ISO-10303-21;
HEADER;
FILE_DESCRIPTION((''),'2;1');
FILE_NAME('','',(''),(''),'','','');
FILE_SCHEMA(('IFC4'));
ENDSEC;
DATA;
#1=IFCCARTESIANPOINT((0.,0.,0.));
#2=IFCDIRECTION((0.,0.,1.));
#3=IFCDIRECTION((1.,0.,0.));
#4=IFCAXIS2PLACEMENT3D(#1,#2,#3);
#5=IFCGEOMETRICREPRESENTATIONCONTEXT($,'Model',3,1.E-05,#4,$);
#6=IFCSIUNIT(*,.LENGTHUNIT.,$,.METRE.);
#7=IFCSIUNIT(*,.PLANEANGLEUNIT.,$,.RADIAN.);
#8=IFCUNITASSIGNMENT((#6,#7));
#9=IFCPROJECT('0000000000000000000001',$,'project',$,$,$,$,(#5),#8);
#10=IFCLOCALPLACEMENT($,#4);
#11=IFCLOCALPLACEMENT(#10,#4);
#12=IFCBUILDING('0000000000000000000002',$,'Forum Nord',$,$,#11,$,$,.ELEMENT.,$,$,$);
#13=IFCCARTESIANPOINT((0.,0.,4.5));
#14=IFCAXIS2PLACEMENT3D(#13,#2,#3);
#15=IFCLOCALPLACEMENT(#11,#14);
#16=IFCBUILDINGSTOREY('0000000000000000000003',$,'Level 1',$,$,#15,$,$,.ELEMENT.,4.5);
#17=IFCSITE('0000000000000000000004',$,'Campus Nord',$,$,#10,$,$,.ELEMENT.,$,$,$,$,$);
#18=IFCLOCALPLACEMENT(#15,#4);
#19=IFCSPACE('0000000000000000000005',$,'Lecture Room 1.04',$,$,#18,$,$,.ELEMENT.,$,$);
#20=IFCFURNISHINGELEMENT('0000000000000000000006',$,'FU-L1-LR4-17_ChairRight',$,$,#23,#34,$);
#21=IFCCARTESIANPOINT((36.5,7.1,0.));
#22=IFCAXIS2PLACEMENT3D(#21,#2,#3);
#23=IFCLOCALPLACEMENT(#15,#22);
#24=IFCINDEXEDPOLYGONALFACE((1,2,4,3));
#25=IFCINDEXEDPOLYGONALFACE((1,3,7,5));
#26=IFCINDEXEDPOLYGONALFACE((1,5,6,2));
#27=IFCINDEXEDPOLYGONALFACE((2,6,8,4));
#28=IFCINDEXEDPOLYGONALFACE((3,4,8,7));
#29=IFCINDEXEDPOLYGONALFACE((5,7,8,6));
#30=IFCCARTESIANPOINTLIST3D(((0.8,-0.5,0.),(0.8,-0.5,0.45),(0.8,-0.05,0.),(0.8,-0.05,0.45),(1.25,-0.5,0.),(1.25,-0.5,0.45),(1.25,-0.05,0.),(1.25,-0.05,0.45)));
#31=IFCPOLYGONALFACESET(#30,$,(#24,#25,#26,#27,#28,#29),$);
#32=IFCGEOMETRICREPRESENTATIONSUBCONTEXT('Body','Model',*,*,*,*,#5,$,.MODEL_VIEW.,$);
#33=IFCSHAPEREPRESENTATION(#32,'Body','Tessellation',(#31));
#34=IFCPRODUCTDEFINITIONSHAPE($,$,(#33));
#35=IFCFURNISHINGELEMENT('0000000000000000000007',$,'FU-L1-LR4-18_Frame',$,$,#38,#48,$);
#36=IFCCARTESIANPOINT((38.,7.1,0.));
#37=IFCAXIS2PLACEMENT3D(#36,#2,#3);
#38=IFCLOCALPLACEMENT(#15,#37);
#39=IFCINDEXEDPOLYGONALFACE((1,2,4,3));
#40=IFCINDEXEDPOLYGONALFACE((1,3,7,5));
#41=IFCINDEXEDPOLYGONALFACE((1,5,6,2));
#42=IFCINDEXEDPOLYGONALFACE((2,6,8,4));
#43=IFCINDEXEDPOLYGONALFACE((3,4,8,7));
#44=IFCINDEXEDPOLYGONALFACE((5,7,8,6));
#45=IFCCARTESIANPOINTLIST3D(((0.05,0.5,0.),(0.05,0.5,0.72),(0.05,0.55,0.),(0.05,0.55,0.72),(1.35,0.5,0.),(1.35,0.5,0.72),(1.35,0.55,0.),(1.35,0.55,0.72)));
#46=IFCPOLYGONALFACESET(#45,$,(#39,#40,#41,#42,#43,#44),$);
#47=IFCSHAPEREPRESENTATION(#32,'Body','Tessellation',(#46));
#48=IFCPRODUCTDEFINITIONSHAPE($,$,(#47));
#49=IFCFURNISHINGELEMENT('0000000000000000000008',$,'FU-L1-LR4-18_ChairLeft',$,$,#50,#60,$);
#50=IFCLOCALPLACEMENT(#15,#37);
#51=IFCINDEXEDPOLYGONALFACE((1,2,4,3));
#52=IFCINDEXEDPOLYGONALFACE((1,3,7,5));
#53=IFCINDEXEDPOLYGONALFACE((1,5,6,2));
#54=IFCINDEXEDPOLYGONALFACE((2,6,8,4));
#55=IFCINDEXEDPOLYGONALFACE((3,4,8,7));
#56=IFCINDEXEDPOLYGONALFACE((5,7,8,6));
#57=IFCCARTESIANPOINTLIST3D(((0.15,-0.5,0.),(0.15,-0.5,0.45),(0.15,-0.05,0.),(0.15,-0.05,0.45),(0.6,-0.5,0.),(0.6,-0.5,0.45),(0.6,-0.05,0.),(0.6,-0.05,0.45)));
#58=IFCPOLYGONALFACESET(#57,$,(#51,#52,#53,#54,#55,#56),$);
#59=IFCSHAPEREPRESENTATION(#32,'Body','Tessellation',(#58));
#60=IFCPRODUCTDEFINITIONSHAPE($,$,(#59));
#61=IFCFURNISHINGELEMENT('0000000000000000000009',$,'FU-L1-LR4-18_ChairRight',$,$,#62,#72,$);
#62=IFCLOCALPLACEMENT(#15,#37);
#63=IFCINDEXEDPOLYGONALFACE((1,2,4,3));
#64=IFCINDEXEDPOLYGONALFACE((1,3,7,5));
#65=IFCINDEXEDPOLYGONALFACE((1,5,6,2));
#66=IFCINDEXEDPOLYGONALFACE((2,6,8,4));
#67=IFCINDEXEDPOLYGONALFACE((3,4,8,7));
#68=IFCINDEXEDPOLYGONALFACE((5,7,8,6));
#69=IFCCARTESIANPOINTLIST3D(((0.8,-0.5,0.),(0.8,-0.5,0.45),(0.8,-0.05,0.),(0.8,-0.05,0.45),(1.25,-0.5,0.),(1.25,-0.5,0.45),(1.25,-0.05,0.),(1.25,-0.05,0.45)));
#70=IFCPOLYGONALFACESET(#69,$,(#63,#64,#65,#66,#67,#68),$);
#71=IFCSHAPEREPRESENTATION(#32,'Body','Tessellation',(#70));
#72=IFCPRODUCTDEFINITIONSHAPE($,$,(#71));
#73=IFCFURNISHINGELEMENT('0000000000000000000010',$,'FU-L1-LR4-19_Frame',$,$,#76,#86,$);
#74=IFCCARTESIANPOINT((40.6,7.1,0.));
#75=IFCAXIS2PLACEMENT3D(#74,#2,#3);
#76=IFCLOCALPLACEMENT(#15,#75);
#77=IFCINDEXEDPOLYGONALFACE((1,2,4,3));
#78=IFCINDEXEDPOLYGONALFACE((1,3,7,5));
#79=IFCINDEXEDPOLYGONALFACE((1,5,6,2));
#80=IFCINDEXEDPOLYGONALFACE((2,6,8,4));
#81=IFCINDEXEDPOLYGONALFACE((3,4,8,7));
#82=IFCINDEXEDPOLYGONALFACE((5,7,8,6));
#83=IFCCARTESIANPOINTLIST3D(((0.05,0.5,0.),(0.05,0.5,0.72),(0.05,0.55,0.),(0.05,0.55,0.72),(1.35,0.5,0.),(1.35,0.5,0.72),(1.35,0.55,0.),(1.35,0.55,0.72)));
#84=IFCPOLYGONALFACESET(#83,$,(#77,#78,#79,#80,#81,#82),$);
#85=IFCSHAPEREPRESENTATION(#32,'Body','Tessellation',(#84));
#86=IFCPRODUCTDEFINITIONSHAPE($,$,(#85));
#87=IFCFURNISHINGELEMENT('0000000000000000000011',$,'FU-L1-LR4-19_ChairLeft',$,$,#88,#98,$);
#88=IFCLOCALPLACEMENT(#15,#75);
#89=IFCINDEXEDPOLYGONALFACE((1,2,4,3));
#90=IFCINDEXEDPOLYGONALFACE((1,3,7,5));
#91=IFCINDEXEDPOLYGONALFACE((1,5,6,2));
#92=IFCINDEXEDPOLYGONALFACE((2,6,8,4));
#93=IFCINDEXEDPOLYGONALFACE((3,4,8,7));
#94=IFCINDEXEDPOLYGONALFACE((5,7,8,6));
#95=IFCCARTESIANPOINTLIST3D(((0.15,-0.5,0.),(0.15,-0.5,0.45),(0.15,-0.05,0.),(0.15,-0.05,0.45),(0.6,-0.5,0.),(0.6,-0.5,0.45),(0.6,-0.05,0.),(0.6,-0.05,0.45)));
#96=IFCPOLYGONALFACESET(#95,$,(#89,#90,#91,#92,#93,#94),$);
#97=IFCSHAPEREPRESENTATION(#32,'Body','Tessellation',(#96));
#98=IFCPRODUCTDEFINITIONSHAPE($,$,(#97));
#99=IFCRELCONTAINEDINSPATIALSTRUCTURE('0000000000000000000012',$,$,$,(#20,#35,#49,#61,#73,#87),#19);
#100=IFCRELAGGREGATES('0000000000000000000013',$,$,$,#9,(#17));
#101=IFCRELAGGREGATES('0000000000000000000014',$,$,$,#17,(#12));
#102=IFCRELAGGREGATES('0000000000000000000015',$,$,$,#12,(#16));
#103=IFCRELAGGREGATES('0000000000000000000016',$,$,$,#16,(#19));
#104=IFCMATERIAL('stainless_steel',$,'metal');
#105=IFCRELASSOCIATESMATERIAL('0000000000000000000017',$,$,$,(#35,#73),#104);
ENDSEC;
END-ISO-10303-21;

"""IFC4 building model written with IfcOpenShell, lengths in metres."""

from ifc_helpers import new_model, si_unit, frame, frame_2d, origin_with_axes, place, context, subcontext, project, spatial, rectangle, extrude, material, element, save


model = new_model("IFC4")

# Units and contexts
model_context = context("Model", 3, precision=1e-05, world=origin_with_axes())
body_context = subcontext(model_context, "Body", "Model", "MODEL_VIEW")
ifc_project = project(units=[si_unit("LENGTHUNIT", "METRE"), si_unit("PLANEANGLEUNIT", "RADIAN")], contexts=[model_context])

# Site, building, storey, space
site_placement = place(None, origin_with_axes())
site = spatial("IfcSite", under=ifc_project, at=site_placement, Name="Campus Nord", CompositionType="ELEMENT")
building_placement = place(site_placement, origin_with_axes())
building = spatial("IfcBuilding", under=site, at=building_placement, Name="Forum Nord", CompositionType="ELEMENT")
storey_placement = place(building_placement, frame((0.0, 0.0, 4.5), z_axis=(0.0, 0.0, 1.0), x_axis=(1.0, 0.0, 0.0)))
storey = spatial("IfcBuildingStorey", under=building, at=storey_placement, Name="Level 1", CompositionType="ELEMENT", Elevation=4.5)
space_placement = place(storey_placement, origin_with_axes())
space = spatial("IfcSpace", under=storey, at=space_placement, Name="Lecture Room 1.04", CompositionType="ELEMENT")

# Furnishing elements
ifc_material_1 = material(Name="stainless_steel", Category="metal")
furnishing_1_placement = place(storey_placement, frame((36.5, 7.1, 0.0), z_axis=(0.0, 0.0, 1.0), x_axis=(1.0, 0.0, 0.0)))
element("IfcFurnishingElement", 1, at=furnishing_1_placement, inside=space, Name="FU-L1-LR4-17_ChairRight", context=body_context, shape_type="SweptSolid", body=[
    extrude(rectangle(XDim=0.45, YDim=0.45, at=frame_2d((1.025, -0.275), x_axis=(1.0, 0.0))), origin_with_axes(), (0.0, 0.0, 1.0), 0.45),
])
furnishing_2_placement = place(storey_placement, frame((38.0, 7.1, 0.0), z_axis=(0.0, 0.0, 1.0), x_axis=(1.0, 0.0, 0.0)))
element("IfcFurnishingElement", 2, at=furnishing_2_placement, inside=space, material=ifc_material_1, Name="FU-L1-LR4-18_Frame", context=body_context, shape_type="SweptSolid", body=[
    extrude(rectangle(XDim=1.3, YDim=0.05, at=frame_2d((0.7, 0.525), x_axis=(1.0, 0.0))), origin_with_axes(), (0.0, 0.0, 1.0), 0.72),
])
furnishing_3_placement = place(storey_placement, frame((38.0, 7.1, 0.0), z_axis=(0.0, 0.0, 1.0), x_axis=(1.0, 0.0, 0.0)))
element("IfcFurnishingElement", 3, at=furnishing_3_placement, inside=space, Name="FU-L1-LR4-18_ChairLeft", context=body_context, shape_type="SweptSolid", body=[
    extrude(rectangle(XDim=0.45, YDim=0.45, at=frame_2d((0.375, -0.275), x_axis=(1.0, 0.0))), origin_with_axes(), (0.0, 0.0, 1.0), 0.45),
])
furnishing_4_placement = place(storey_placement, frame((38.0, 7.1, 0.0), z_axis=(0.0, 0.0, 1.0), x_axis=(1.0, 0.0, 0.0)))
element("IfcFurnishingElement", 4, at=furnishing_4_placement, inside=space, Name="FU-L1-LR4-18_ChairRight", context=body_context, shape_type="SweptSolid", body=[
    extrude(rectangle(XDim=0.45, YDim=0.45, at=frame_2d((1.025, -0.275), x_axis=(1.0, 0.0))), origin_with_axes(), (0.0, 0.0, 1.0), 0.45),
])
furnishing_5_placement = place(storey_placement, frame((40.6, 7.1, 0.0), z_axis=(0.0, 0.0, 1.0), x_axis=(1.0, 0.0, 0.0)))
element("IfcFurnishingElement", 5, at=furnishing_5_placement, inside=space, material=ifc_material_1, Name="FU-L1-LR4-19_Frame", context=body_context, shape_type="SweptSolid", body=[
    extrude(rectangle(XDim=1.3, YDim=0.05, at=frame_2d((0.7, 0.525), x_axis=(1.0, 0.0))), origin_with_axes(), (0.0, 0.0, 1.0), 0.72),
])
furnishing_6_placement = place(storey_placement, frame((40.6, 7.1, 0.0), z_axis=(0.0, 0.0, 1.0), x_axis=(1.0, 0.0, 0.0)))
element("IfcFurnishingElement", 6, at=furnishing_6_placement, inside=space, Name="FU-L1-LR4-19_ChairLeft", context=body_context, shape_type="SweptSolid", body=[
    extrude(rectangle(XDim=0.45, YDim=0.45, at=frame_2d((0.375, -0.275), x_axis=(1.0, 0.0))), origin_with_axes(), (0.0, 0.0, 1.0), 0.45),
])

save(model, "model.ifc")
